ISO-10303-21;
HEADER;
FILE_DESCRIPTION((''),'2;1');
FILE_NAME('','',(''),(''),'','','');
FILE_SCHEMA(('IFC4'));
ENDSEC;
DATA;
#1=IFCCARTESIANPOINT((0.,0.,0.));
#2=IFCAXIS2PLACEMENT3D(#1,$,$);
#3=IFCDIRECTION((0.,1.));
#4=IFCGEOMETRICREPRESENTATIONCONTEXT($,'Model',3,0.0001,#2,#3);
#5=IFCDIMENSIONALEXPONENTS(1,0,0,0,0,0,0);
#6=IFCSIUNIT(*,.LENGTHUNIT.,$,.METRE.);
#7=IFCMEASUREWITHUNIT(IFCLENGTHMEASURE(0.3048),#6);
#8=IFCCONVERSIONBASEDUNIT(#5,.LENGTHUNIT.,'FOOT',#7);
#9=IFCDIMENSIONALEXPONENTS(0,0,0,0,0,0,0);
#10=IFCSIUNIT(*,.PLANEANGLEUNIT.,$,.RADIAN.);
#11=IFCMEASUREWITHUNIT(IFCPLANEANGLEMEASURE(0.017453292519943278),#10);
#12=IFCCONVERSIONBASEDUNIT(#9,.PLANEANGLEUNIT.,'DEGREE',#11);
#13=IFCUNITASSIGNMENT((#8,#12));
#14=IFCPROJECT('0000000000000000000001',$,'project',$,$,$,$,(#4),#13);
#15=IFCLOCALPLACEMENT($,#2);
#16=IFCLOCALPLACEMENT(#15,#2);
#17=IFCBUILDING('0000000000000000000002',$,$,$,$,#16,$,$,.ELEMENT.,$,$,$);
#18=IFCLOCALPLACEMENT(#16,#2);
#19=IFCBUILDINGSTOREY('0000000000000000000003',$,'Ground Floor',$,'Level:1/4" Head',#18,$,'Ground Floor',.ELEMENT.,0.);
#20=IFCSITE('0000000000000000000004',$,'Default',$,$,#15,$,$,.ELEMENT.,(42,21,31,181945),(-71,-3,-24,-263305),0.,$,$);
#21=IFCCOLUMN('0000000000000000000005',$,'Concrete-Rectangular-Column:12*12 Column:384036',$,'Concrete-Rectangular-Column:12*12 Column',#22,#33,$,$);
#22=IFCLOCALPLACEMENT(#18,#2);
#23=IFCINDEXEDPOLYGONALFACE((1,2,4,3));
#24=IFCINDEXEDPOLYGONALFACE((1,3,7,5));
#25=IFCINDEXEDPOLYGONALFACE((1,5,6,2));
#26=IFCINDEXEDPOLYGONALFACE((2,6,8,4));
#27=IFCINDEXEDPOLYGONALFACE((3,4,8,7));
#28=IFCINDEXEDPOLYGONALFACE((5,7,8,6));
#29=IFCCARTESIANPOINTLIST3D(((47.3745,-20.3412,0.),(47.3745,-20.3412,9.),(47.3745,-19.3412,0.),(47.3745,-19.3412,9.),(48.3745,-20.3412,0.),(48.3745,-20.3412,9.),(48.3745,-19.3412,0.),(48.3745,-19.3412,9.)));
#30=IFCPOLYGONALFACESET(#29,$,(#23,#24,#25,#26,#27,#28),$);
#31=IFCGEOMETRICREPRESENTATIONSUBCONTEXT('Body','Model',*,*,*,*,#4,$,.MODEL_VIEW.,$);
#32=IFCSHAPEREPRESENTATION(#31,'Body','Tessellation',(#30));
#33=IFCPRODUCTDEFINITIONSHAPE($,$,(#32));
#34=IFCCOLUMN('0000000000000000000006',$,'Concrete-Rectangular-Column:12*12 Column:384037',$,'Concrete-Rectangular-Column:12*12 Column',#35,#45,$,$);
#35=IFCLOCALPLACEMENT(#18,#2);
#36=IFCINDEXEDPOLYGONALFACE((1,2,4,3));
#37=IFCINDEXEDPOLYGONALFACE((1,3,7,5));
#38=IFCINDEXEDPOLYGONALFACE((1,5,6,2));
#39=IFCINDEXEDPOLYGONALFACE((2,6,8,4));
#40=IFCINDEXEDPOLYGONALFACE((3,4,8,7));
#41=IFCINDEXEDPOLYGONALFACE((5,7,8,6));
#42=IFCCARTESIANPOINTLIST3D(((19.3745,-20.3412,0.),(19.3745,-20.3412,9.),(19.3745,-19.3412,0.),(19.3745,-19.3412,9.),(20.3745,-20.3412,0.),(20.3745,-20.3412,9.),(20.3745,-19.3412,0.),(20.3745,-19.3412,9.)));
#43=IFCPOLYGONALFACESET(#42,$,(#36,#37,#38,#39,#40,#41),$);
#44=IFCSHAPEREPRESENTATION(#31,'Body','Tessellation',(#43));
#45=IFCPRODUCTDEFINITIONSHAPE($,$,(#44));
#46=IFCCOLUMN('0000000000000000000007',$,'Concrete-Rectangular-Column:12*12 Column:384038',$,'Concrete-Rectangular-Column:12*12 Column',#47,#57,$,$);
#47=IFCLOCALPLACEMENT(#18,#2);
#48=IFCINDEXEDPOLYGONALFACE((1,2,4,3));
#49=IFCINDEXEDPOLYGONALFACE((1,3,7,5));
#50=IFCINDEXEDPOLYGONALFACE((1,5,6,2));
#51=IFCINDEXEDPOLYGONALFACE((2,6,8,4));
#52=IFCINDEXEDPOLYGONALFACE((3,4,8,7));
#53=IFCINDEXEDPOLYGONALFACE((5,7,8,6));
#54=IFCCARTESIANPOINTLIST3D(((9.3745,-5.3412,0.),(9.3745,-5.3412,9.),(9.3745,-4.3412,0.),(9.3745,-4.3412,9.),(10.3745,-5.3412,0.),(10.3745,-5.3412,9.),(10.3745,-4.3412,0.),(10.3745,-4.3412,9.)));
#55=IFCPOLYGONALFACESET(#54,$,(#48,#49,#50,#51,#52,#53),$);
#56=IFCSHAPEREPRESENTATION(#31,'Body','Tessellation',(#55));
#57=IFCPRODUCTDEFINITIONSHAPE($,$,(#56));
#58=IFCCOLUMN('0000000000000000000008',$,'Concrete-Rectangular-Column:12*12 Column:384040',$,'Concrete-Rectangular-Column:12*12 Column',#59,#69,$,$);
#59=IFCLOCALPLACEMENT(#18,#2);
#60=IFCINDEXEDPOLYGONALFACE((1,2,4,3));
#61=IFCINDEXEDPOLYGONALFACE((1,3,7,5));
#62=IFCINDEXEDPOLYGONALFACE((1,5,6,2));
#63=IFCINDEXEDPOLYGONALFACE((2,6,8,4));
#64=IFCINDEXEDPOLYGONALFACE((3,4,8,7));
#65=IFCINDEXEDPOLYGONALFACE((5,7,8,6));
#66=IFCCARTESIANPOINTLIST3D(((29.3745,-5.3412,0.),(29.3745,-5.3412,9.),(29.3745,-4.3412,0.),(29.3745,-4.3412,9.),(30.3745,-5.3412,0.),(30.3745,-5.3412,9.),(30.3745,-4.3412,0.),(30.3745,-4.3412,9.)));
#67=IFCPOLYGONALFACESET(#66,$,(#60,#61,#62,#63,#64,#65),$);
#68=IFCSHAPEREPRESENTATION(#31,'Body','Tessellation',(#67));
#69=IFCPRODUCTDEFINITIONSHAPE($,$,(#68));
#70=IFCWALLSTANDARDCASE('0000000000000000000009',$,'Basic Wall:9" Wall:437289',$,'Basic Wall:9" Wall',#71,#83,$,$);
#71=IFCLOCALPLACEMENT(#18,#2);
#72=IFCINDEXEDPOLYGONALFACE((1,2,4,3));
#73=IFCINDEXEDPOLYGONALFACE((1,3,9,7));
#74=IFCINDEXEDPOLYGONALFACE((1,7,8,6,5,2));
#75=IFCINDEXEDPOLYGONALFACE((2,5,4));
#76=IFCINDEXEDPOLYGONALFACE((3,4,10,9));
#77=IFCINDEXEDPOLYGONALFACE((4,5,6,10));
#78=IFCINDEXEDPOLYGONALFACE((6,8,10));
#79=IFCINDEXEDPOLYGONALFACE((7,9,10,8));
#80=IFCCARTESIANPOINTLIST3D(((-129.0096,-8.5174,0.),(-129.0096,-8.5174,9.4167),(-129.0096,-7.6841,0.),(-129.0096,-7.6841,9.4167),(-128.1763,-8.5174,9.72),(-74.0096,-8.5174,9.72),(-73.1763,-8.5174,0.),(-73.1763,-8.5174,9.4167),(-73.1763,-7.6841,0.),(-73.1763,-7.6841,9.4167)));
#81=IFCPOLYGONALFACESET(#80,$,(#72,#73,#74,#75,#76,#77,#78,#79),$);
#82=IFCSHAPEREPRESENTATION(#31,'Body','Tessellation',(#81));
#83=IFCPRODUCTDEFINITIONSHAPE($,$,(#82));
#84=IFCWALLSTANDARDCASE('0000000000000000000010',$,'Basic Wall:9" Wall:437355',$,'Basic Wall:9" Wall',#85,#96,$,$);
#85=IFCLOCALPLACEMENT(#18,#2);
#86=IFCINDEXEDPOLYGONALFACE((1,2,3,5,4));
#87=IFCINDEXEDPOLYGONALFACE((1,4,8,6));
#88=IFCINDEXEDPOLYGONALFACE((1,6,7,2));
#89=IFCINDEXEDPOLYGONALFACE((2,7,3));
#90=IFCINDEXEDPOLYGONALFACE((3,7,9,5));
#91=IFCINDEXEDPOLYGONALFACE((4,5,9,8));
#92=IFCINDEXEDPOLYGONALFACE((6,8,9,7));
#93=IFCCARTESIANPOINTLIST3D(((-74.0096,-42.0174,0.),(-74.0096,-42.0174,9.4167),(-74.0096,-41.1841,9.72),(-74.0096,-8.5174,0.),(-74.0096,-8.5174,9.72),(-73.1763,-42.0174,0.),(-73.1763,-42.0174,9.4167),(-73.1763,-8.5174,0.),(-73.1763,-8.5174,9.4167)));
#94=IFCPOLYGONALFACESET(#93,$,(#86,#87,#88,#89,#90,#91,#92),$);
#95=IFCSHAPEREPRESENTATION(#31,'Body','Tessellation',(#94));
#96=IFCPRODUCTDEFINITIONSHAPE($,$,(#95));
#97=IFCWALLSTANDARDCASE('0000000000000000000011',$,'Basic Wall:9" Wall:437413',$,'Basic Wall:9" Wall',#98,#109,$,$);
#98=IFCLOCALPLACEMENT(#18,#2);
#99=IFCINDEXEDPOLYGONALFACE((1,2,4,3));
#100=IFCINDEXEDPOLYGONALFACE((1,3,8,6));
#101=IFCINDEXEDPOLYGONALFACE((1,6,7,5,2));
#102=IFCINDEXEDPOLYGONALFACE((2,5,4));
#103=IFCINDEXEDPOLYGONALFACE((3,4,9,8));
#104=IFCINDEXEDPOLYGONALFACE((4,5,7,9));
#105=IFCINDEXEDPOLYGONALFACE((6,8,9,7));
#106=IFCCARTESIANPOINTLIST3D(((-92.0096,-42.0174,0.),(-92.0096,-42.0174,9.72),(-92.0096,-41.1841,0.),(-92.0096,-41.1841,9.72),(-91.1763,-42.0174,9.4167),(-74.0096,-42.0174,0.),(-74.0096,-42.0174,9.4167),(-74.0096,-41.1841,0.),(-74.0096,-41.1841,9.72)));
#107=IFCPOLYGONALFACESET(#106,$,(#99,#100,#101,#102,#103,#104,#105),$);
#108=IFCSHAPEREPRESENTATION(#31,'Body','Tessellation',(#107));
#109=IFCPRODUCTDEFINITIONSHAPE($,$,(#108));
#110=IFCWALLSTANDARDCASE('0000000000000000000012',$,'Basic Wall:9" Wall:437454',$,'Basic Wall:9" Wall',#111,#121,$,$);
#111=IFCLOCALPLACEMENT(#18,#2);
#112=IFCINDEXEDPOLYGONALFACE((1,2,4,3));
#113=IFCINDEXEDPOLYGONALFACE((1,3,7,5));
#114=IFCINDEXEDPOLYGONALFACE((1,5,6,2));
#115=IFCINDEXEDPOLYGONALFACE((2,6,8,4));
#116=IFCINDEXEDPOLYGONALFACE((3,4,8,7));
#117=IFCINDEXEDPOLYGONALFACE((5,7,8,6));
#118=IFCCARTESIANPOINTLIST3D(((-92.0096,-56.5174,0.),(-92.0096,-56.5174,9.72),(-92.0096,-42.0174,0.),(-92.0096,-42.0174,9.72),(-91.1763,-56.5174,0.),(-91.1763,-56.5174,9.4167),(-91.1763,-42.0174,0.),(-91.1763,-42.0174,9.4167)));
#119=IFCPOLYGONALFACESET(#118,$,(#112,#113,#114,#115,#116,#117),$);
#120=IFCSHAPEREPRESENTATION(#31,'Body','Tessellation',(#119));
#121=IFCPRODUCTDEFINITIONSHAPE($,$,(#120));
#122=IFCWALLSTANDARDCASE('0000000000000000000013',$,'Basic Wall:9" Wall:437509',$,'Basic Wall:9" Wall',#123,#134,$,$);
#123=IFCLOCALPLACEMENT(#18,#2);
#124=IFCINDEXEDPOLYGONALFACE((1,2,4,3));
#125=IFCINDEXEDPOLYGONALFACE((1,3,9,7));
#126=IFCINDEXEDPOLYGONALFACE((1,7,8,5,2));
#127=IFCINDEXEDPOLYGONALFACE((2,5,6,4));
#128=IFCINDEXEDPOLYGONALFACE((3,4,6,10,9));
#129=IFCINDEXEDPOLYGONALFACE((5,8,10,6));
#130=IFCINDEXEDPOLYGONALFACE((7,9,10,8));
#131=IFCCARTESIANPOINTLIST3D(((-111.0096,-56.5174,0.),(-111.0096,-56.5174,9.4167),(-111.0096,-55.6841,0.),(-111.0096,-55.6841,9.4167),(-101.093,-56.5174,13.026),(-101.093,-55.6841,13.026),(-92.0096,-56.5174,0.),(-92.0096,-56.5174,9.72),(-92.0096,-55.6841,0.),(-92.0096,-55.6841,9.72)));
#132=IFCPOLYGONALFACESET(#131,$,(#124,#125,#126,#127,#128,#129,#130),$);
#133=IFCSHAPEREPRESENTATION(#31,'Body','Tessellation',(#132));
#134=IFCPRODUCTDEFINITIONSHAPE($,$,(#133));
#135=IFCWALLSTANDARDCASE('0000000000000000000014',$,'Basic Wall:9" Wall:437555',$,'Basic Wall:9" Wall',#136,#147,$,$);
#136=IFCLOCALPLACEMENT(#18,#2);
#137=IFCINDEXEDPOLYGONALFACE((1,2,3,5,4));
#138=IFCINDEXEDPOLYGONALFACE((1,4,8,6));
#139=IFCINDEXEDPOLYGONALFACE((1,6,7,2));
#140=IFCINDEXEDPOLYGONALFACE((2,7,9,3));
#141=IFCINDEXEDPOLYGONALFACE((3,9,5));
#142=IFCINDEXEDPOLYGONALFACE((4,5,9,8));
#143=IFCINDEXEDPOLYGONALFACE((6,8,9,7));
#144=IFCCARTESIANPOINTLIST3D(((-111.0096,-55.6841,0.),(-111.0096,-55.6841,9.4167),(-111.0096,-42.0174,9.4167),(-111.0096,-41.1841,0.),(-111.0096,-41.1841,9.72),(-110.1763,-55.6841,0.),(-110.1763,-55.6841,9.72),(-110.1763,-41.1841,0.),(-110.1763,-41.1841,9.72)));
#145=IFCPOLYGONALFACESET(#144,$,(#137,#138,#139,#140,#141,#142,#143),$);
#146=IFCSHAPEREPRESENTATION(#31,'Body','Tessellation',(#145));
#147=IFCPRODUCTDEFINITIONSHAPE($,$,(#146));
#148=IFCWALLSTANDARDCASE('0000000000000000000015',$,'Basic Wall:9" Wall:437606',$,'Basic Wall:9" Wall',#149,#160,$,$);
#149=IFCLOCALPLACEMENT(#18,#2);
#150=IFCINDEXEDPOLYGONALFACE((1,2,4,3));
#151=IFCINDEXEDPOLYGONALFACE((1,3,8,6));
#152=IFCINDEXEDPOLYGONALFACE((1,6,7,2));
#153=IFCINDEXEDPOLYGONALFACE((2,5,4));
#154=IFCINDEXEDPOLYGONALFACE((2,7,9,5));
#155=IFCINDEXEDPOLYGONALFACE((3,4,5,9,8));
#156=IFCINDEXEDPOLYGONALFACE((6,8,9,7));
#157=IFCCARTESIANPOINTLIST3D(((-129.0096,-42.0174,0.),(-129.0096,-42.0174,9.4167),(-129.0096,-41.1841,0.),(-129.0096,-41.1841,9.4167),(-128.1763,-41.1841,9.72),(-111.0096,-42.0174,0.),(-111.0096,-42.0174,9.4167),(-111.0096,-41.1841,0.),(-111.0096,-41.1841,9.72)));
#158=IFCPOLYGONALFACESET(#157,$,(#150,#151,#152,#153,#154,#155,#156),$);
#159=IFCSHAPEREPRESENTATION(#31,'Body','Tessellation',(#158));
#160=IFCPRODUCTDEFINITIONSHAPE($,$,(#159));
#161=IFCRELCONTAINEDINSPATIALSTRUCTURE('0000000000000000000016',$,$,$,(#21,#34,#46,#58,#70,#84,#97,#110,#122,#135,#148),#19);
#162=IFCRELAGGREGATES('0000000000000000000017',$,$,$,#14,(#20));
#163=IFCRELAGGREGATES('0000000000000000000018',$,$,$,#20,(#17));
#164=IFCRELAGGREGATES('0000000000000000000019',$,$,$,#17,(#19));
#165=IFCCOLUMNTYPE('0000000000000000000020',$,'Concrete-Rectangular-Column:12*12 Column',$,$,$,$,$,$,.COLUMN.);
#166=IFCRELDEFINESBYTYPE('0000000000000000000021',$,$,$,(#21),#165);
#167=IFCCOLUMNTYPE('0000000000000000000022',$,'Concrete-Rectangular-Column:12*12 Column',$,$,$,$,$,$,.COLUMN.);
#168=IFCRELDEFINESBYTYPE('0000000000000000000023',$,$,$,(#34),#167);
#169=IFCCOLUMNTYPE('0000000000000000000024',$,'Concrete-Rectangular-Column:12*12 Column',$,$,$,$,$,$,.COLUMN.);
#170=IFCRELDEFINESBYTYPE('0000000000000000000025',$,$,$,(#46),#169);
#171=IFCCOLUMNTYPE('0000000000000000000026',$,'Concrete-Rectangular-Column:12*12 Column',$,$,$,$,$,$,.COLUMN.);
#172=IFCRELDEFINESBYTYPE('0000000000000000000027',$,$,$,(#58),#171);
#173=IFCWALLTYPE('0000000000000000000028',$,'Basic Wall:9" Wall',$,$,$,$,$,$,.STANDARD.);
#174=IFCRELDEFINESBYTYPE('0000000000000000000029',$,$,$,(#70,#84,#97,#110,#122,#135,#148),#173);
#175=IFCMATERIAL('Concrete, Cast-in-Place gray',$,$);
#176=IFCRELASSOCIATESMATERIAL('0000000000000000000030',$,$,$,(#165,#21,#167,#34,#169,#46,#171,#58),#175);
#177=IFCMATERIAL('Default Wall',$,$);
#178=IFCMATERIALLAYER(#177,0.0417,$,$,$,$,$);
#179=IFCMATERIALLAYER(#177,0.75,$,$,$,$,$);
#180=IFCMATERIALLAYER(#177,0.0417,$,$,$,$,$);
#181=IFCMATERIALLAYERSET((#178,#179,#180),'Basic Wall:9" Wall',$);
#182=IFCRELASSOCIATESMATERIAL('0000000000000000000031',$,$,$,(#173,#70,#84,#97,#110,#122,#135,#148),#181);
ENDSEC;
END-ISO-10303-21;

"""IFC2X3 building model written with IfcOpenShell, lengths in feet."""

from ifc_helpers import new_model, entity, si_unit, converted_unit, direction, frame, frame_2d, origin, origin_2d_with_axis, place, context, subcontext, project, spatial, polyline, rectangle, extrude, clip, bounded_halfspace, source, transform, mapped, material, layer, layer_set, layer_usage, type_object, type_shapes, element, save


model = new_model("IFC2X3")

# Units and contexts
model_context = context("Model", 3, precision=0.0001, world=origin(), true_north=direction((0.0, 1.0)))
body_context = subcontext(model_context, "Body", "Model", "MODEL_VIEW")
ifc_project = project(units=[converted_unit("LENGTHUNIT", "FOOT", entity("IfcLengthMeasure", 0.3048), si_unit("LENGTHUNIT", "METRE"), dimensions=[1, 0, 0, 0, 0, 0, 0]), converted_unit("PLANEANGLEUNIT", "DEGREE", entity("IfcPlaneAngleMeasure", 0.017453292519943278), si_unit("PLANEANGLEUNIT", "RADIAN"), dimensions=[0, 0, 0, 0, 0, 0, 0])], contexts=[model_context])

# Site, building, storey
site_placement = place(None, origin())
site = spatial("IfcSite", under=ifc_project, at=site_placement, Name="Default", CompositionType="ELEMENT", RefLatitude=(42, 21, 31, 181945), RefLongitude=(-71, -3, -24, -263305), RefElevation=0.0)
building_placement = place(site_placement, origin())
building = spatial("IfcBuilding", under=site, at=building_placement, CompositionType="ELEMENT")
storey_placement = place(building_placement, origin())
storey = spatial("IfcBuildingStorey", under=building, at=storey_placement, Name="Ground Floor", ObjectType="Level:1/4\" Head", LongName="Ground Floor", CompositionType="ELEMENT", Elevation=0.0)

# Columns
ifc_material_1 = material(Name="Concrete, Cast-in-Place gray")
column_type_1 = type_object("IfcColumnType", Name="Concrete-Rectangular-Column:12*12 Column", PredefinedType="COLUMN", material=ifc_material_1)
shared_shape_1 = source(origin(), body_context, "Body", "SweptSolid", [
    extrude(rectangle(XDim=1.0, YDim=1.0, at=frame_2d((0.0, 0.0), x_axis=(1.0, 0.0))), frame((47.8745, -19.8412, 0.0), z_axis=(0.0, 0.0, 1.0), x_axis=(-1.0, 0.0, 0.0)), (0.0, 0.0, 1.0), 9.0),
])
type_shapes(column_type_1, [shared_shape_1])
column_1_placement = place(storey_placement, origin())
element("IfcColumn", 1, at=column_1_placement, inside=storey, type_object=column_type_1, material=ifc_material_1, Name="Concrete-Rectangular-Column:12*12 Column:384036", ObjectType="Concrete-Rectangular-Column:12*12 Column", context=body_context, shape_type="MappedRepresentation", body=[
    mapped(shared_shape_1, transform((0.0, 0.0, 0.0), scale=1.0)),
])
column_type_2 = type_object("IfcColumnType", Name="Concrete-Rectangular-Column:12*12 Column", PredefinedType="COLUMN", material=ifc_material_1)
shared_shape_2 = source(origin(), body_context, "Body", "SweptSolid", [
    extrude(rectangle(XDim=1.0, YDim=1.0, at=frame_2d((0.0, 0.0), x_axis=(1.0, 0.0))), frame((19.8745, -19.8412, 0.0), z_axis=(0.0, 0.0, 1.0), x_axis=(-1.0, 0.0, 0.0)), (0.0, 0.0, 1.0), 9.0),
])
type_shapes(column_type_2, [shared_shape_2])
column_2_placement = place(storey_placement, origin())
element("IfcColumn", 2, at=column_2_placement, inside=storey, type_object=column_type_2, material=ifc_material_1, Name="Concrete-Rectangular-Column:12*12 Column:384037", ObjectType="Concrete-Rectangular-Column:12*12 Column", context=body_context, shape_type="MappedRepresentation", body=[
    mapped(shared_shape_2, transform((0.0, 0.0, 0.0), scale=1.0)),
])
column_type_3 = type_object("IfcColumnType", Name="Concrete-Rectangular-Column:12*12 Column", PredefinedType="COLUMN", material=ifc_material_1)
shared_shape_3 = source(origin(), body_context, "Body", "SweptSolid", [
    extrude(rectangle(XDim=1.0, YDim=1.0, at=origin_2d_with_axis()), frame((9.8745, -4.8412, 0.0), z_axis=(0.0, 0.0, 1.0), x_axis=(-1.0, 0.0, 0.0)), (0.0, 0.0, 1.0), 9.0),
])
type_shapes(column_type_3, [shared_shape_3])
column_3_placement = place(storey_placement, origin())
element("IfcColumn", 3, at=column_3_placement, inside=storey, type_object=column_type_3, material=ifc_material_1, Name="Concrete-Rectangular-Column:12*12 Column:384038", ObjectType="Concrete-Rectangular-Column:12*12 Column", context=body_context, shape_type="MappedRepresentation", body=[
    mapped(shared_shape_3, transform((0.0, 0.0, 0.0), scale=1.0)),
])
column_type_4 = type_object("IfcColumnType", Name="Concrete-Rectangular-Column:12*12 Column", PredefinedType="COLUMN", material=ifc_material_1)
shared_shape_4 = source(origin(), body_context, "Body", "SweptSolid", [
    extrude(rectangle(XDim=1.0, YDim=1.0, at=frame_2d((0.0, 0.0), x_axis=(1.0, 0.0))), frame((29.8745, -4.8412, 0.0), z_axis=(0.0, 0.0, 1.0), x_axis=(-1.0, 0.0, 0.0)), (0.0, 0.0, 1.0), 9.0),
])
type_shapes(column_type_4, [shared_shape_4])
column_4_placement = place(storey_placement, origin())
element("IfcColumn", 4, at=column_4_placement, inside=storey, type_object=column_type_4, material=ifc_material_1, Name="Concrete-Rectangular-Column:12*12 Column:384040", ObjectType="Concrete-Rectangular-Column:12*12 Column", context=body_context, shape_type="MappedRepresentation", body=[
    mapped(shared_shape_4, transform((0.0, 0.0, 0.0), scale=1.0)),
])

# Walls
ifc_material_2 = material(Name="Default Wall")
ifc_layer_1 = layer(ifc_material_2, 0.0417)
ifc_layer_2 = layer(ifc_material_2, 0.75)
ifc_layer_3 = layer(ifc_material_2, 0.0417)
ifc_layer_set = layer_set([ifc_layer_1, ifc_layer_2, ifc_layer_3], Name="Basic Wall:9\" Wall")
ifc_layer_usage = layer_usage(ifc_layer_set, "AXIS2", "NEGATIVE", 0.4167)
wall_type = type_object("IfcWallType", Name="Basic Wall:9\" Wall", PredefinedType="STANDARD", material=ifc_layer_set)
wall_1_placement = place(storey_placement, frame((-129.0096, -8.1008, 0.0)))
element("IfcWallStandardCase", 5, at=wall_1_placement, inside=storey, type_object=wall_type, material=ifc_layer_usage, Name="Basic Wall:9\" Wall:437289", ObjectType="Basic Wall:9\" Wall", context=body_context, shape_type="Clipping", body=[
    clip(clip(clip(extrude(rectangle(XDim=55.8333, YDim=0.8333, at=frame_2d((27.9167, 0.0), x_axis=(-1.0, 0.0))), origin(), (0.0, 0.0, 1.0), 9.72), bounded_halfspace(frame((0.0, -0.4167, 9.4167), z_axis=(-0.34202, 0.0, 0.939693), x_axis=(0.0, -1.0, 0.0)), False, frame((0.0, -0.4167, 9.4167)), polyline([(0.0, 0.0), (0.8333, 0.0), (0.0, 0.8333), (0.0, 0.0)]))), bounded_halfspace(frame((55.0, -0.4167, 9.72), z_axis=(0.34202, 0.0, 0.939693), x_axis=(0.0, 1.0, 0.0)), False, frame((55.0, -0.4167, 9.72)), polyline([(0.0, 0.0), (0.8333, 0.0), (0.8333, 0.8333), (0.0, 0.0)]))), bounded_halfspace(frame((0.8333, -0.4167, 9.72), z_axis=(0.0, 0.34202, 0.939693), x_axis=(-1.0, 0.0, 0.0)), False, frame((0.8333, -0.4167, 9.72)), polyline([(0.0, 0.0), (54.1667, 0.0), (55.0, 0.8333), (-0.8333, 0.8333), (0.0, 0.0)]))),
])
wall_2_placement = place(storey_placement, frame((-73.593, -8.5174, 0.0), z_axis=(0.0, 0.0, 1.0), x_axis=(0.0, -1.0, 0.0)))
element("IfcWallStandardCase", 6, at=wall_2_placement, inside=storey, type_object=wall_type, material=ifc_layer_usage, Name="Basic Wall:9\" Wall:437355", ObjectType="Basic Wall:9\" Wall", context=body_context, shape_type="Clipping", body=[
    clip(clip(extrude(rectangle(XDim=33.5, YDim=0.8333, at=frame_2d((16.75, 0.0), x_axis=(-1.0, 0.0))), origin(), (0.0, 0.0, 1.0), 9.72), bounded_halfspace(frame((0.0, -0.4167, 9.72), z_axis=(0.0, 0.34202, 0.939693), x_axis=(-1.0, 0.0, 0.0)), False, frame((0.0, -0.4167, 9.72)), polyline([(0.0, 0.0), (32.6667, 0.0), (33.5, 0.8333), (0.0, 0.8333), (0.0, 0.0)]))), bounded_halfspace(frame((32.6667, -0.4167, 9.72), z_axis=(0.34202, 0.0, 0.939693), x_axis=(0.0, 1.0, 0.0)), False, frame((32.6667, -0.4167, 9.72)), polyline([(0.0, 0.0), (0.8333, 0.0), (0.8333, 0.8333), (0.0, 0.0)]))),
])
wall_3_placement = place(storey_placement, frame((-74.0096, -41.6008, 0.0), z_axis=(0.0, 0.0, 1.0), x_axis=(-1.0, 0.0, 0.0)))
element("IfcWallStandardCase", 7, at=wall_3_placement, inside=storey, type_object=wall_type, material=ifc_layer_usage, Name="Basic Wall:9\" Wall:437413", ObjectType="Basic Wall:9\" Wall", context=body_context, shape_type="Clipping", body=[
    clip(clip(extrude(rectangle(XDim=18.0, YDim=0.8333, at=frame_2d((9.0, 0.0), x_axis=(-1.0, 0.0))), origin(), (0.0, 0.0, 1.0), 9.72), bounded_halfspace(frame((18.0, -0.4167, 9.72), z_axis=(-0.34202, 0.0, 0.939693), x_axis=(0.0, -1.0, 0.0)), False, frame((18.0, -0.4167, 9.72)), polyline([(0.0, 0.0), (0.0, 0.8333), (-0.8333, 0.8333), (0.0, 0.0)]))), bounded_halfspace(frame((0.0, -0.4167, 9.72), z_axis=(0.0, 0.34202, 0.939693), x_axis=(-1.0, 0.0, 0.0)), False, frame((0.0, -0.4167, 9.72)), polyline([(0.0, 0.0), (18.0, 0.0), (17.1667, 0.8333), (0.0, 0.8333), (0.0, 0.0)]))),
])
wall_4_placement = place(storey_placement, frame((-91.593, -42.0174, 0.0), z_axis=(0.0, 0.0, 1.0), x_axis=(0.0, -1.0, 0.0)))
element("IfcWallStandardCase", 8, at=wall_4_placement, inside=storey, type_object=wall_type, material=ifc_layer_usage, Name="Basic Wall:9\" Wall:437454", ObjectType="Basic Wall:9\" Wall", context=body_context, shape_type="Clipping", body=[
    clip(extrude(rectangle(XDim=14.5, YDim=0.8333, at=frame_2d((7.25, 0.0), x_axis=(-1.0, 0.0))), origin(), (0.0, 0.0, 1.0), 9.72), bounded_halfspace(frame((0.0, -0.4167, 9.72), z_axis=(0.0, 0.34202, 0.939693), x_axis=(-1.0, 0.0, 0.0)), False, frame((0.0, -0.4167, 9.72)), polyline([(0.0, 0.0), (13.6667, 0.0), (14.5, 0.0), (14.5, 0.8333), (0.0, 0.8333), (0.0, 0.0)]))),
])
wall_5_placement = place(storey_placement, frame((-92.0096, -56.1008, 0.0), z_axis=(0.0, 0.0, 1.0), x_axis=(-1.0, 0.0, 0.0)))
element("IfcWallStandardCase", 9, at=wall_5_placement, inside=storey, type_object=wall_type, material=ifc_layer_usage, Name="Basic Wall:9\" Wall:437509", ObjectType="Basic Wall:9\" Wall", context=body_context, shape_type="Clipping", body=[
    clip(clip(extrude(rectangle(XDim=19.0, YDim=0.8333, at=frame_2d((9.5, 0.0), x_axis=(-1.0, 0.0))), origin(), (0.0, 0.0, 1.0), 13.026), bounded_halfspace(frame((9.0833, -0.4167, 13.026), z_axis=(0.34202, 0.0, 0.939693), x_axis=(0.0, 1.0, 0.0)), False, frame((9.0833, -0.4167, 13.026)), polyline([(0.0, 0.0), (9.0833, 0.0), (9.9167, 0.0), (9.9167, 0.8333), (0.0, 0.8333), (0.0, 0.0)]))), bounded_halfspace(frame((0.0, -0.4167, 9.72), z_axis=(-0.34202, 0.0, 0.939693), x_axis=(0.0, -1.0, 0.0)), False, frame((0.0, -0.4167, 9.72)), polyline([(0.0, 0.0), (9.0833, 0.0), (9.0833, 0.8333), (0.0, 0.8333), (0.0, 0.0)]))),
])
wall_6_placement = place(storey_placement, frame((-110.593, -55.6841, 0.0), z_axis=(0.0, 0.0, 1.0), x_axis=(0.0, 1.0, 0.0)))
element("IfcWallStandardCase", 10, at=wall_6_placement, inside=storey, type_object=wall_type, material=ifc_layer_usage, Name="Basic Wall:9\" Wall:437555", ObjectType="Basic Wall:9\" Wall", context=body_context, shape_type="Clipping", body=[
    clip(clip(extrude(rectangle(XDim=14.5, YDim=0.8333, at=frame_2d((7.25, 0.0), x_axis=(-1.0, 0.0))), origin(), (0.0, 0.0, 1.0), 9.72), bounded_halfspace(frame((0.0, -0.4167, 9.72), z_axis=(0.0, 0.34202, 0.939693), x_axis=(-1.0, 0.0, 0.0)), False, frame((0.0, -0.4167, 9.72)), polyline([(0.0, 0.0), (14.5, 0.0), (13.6667, 0.8333), (0.0, 0.8333), (0.0, 0.0)]))), bounded_halfspace(frame((14.5, -0.4167, 9.72), z_axis=(-0.34202, 0.0, 0.939693), x_axis=(0.0, -1.0, 0.0)), False, frame((14.5, -0.4167, 9.72)), polyline([(0.0, 0.0), (0.0, 0.8333), (-0.8333, 0.8333), (0.0, 0.0)]))),
])
wall_7_placement = place(storey_placement, frame((-111.0096, -41.6008, 0.0), z_axis=(0.0, 0.0, 1.0), x_axis=(-1.0, 0.0, 0.0)))
element("IfcWallStandardCase", 11, at=wall_7_placement, inside=storey, type_object=wall_type, material=ifc_layer_usage, Name="Basic Wall:9\" Wall:437606", ObjectType="Basic Wall:9\" Wall", context=body_context, shape_type="Clipping", body=[
    clip(clip(extrude(rectangle(XDim=18.0, YDim=0.8333, at=frame_2d((9.0, 0.0), x_axis=(-1.0, 0.0))), origin(), (0.0, 0.0, 1.0), 9.72), bounded_halfspace(frame((17.1667, -0.4167, 9.72), z_axis=(0.34202, 0.0, 0.939693), x_axis=(0.0, 1.0, 0.0)), False, frame((17.1667, -0.4167, 9.72)), polyline([(0.0, 0.0), (0.8333, 0.0), (0.8333, 0.8333), (0.0, 0.0)]))), bounded_halfspace(frame((0.0, -0.4167, 9.72), z_axis=(0.0, 0.34202, 0.939693), x_axis=(-1.0, 0.0, 0.0)), False, frame((0.0, -0.4167, 9.72)), polyline([(0.0, 0.0), (17.1667, 0.0), (18.0, 0.8333), (0.0, 0.8333), (0.0, 0.0)]))),
])

save(model, "model.ifc")
